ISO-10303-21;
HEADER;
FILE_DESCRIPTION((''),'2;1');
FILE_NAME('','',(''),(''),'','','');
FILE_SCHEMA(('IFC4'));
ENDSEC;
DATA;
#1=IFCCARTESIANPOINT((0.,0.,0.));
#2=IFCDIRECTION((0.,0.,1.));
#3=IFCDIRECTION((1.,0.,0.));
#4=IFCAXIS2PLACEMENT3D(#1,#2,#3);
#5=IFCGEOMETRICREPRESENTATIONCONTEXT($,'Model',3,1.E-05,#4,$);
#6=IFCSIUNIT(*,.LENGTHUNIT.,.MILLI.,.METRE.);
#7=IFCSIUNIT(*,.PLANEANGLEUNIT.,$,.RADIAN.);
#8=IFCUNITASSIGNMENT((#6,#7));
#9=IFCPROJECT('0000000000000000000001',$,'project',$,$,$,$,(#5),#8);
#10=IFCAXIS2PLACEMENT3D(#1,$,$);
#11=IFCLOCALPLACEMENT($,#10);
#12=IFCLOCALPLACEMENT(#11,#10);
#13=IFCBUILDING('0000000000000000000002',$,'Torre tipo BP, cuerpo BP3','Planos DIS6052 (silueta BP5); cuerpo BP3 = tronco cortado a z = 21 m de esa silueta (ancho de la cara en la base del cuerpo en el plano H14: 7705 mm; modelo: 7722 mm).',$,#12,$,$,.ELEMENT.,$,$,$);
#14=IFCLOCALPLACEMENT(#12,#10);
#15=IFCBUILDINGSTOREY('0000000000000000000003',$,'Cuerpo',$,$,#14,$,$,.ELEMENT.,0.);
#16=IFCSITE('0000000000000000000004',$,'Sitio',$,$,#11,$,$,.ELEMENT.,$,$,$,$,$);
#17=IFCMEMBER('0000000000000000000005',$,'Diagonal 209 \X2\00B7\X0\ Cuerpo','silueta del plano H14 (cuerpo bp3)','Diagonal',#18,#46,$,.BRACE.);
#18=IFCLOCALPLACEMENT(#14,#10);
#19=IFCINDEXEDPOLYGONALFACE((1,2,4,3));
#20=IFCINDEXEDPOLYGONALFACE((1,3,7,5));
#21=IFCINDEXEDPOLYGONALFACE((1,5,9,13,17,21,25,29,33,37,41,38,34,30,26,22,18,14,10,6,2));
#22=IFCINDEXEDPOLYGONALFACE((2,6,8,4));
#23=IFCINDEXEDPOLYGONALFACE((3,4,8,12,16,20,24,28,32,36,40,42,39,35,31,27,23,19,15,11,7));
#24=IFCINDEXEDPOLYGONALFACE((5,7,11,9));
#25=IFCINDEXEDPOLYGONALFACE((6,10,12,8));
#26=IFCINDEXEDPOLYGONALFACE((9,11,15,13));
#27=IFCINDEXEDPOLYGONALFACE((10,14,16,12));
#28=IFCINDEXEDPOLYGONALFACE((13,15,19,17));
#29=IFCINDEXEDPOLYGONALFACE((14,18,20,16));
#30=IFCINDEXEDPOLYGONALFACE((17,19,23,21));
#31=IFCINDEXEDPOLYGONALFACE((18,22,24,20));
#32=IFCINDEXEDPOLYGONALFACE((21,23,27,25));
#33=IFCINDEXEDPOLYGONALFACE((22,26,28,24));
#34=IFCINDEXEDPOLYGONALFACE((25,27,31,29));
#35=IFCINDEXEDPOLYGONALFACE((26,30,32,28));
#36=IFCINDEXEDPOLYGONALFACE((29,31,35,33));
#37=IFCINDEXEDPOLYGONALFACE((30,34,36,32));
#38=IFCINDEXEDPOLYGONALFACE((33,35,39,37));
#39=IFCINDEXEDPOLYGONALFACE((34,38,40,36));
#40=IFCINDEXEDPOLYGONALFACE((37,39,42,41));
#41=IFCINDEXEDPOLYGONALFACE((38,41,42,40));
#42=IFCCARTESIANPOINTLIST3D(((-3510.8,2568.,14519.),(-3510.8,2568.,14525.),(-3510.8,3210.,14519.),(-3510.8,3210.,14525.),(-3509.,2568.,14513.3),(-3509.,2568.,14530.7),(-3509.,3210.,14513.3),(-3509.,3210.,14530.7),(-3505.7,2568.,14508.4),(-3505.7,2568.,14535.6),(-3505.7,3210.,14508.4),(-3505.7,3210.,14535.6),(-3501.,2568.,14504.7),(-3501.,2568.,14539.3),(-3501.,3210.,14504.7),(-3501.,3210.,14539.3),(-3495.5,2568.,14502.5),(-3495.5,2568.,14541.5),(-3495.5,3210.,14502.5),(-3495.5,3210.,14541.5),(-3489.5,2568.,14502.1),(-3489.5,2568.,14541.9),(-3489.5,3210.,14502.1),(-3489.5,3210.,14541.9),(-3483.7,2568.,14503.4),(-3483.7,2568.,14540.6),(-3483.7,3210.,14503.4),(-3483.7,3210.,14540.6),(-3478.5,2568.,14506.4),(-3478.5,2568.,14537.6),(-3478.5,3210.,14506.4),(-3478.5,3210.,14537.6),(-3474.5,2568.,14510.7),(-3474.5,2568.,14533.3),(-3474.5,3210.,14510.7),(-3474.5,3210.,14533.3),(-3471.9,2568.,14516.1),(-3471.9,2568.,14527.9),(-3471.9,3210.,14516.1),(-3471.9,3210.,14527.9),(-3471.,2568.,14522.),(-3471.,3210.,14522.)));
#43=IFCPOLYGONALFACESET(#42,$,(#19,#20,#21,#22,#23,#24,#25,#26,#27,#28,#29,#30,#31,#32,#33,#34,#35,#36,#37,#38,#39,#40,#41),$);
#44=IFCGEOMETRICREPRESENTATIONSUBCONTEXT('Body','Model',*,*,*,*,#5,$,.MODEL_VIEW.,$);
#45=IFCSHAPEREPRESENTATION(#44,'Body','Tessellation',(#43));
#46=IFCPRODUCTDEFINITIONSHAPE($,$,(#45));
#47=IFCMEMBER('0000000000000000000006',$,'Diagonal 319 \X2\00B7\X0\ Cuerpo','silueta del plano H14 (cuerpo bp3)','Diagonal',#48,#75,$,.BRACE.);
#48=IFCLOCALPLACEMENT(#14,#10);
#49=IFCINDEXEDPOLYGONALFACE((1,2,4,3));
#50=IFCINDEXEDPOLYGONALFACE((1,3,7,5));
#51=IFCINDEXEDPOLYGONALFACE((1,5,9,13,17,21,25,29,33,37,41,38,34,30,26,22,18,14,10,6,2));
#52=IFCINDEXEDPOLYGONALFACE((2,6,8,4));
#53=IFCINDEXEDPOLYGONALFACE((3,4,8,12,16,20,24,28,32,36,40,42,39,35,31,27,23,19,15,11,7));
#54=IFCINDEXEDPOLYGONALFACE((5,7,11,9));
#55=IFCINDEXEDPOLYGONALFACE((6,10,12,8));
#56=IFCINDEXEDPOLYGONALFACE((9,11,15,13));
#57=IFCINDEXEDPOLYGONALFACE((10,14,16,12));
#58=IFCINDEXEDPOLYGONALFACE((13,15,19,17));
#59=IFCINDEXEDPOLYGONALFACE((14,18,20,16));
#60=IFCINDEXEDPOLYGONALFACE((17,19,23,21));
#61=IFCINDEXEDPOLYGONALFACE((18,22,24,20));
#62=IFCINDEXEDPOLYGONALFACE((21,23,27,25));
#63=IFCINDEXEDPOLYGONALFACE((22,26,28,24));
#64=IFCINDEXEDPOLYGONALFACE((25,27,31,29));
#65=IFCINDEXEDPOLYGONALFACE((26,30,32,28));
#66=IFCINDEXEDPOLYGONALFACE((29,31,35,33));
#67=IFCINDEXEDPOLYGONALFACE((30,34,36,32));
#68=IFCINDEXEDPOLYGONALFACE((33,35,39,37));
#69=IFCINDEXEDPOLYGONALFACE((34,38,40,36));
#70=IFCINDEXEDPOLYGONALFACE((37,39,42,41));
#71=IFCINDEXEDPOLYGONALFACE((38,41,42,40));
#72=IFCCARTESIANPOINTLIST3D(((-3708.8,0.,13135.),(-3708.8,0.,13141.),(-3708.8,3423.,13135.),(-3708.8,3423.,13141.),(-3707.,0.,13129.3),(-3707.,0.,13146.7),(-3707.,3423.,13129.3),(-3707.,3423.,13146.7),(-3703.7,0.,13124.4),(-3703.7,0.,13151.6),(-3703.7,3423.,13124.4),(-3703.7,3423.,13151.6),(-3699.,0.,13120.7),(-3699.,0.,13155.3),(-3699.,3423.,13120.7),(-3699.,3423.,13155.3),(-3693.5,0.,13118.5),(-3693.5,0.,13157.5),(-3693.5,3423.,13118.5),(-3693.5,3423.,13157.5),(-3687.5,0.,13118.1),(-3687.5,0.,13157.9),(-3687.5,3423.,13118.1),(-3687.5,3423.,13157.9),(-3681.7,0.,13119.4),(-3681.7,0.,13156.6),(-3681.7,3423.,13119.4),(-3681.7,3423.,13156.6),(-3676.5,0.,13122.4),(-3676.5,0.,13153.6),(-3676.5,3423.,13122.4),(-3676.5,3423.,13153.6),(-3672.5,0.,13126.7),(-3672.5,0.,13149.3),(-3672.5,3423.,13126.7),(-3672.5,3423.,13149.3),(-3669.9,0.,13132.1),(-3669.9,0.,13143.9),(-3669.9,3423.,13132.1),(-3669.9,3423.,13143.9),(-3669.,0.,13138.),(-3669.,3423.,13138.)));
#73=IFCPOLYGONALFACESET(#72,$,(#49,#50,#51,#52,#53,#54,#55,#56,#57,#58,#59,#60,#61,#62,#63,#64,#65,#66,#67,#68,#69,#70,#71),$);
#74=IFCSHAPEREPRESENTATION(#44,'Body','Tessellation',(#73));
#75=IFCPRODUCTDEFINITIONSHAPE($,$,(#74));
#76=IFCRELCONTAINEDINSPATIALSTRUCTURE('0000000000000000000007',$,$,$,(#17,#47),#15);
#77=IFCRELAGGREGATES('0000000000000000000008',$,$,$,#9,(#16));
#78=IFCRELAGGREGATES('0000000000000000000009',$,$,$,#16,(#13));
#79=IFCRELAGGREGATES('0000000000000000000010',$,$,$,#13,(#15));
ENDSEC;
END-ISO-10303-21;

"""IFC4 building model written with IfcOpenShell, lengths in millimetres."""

from ifc_helpers import new_model, si_unit, frame, origin, origin_with_axes, place, context, subcontext, project, spatial, circle, extrude, element, save


model = new_model("IFC4")

# Units and contexts
model_context = context("Model", 3, precision=1e-05, world=origin_with_axes())
body_context = subcontext(model_context, "Body", "Model", "MODEL_VIEW")
ifc_project = project(units=[si_unit("LENGTHUNIT", "METRE", prefix="MILLI"), si_unit("PLANEANGLEUNIT", "RADIAN")], contexts=[model_context])

# Site, building, storey
site_placement = place(None, origin())
site = spatial("IfcSite", under=ifc_project, at=site_placement, Name="Sitio", CompositionType="ELEMENT")
building_placement = place(site_placement, origin())
building = spatial("IfcBuilding", under=site, at=building_placement, Name="Torre tipo BP, cuerpo BP3", Description="Planos DIS6052 (silueta BP5); cuerpo BP3 = tronco cortado a z = 21 m de esa silueta (ancho de la cara en la base del cuerpo en el plano H14: 7705 mm; modelo: 7722 mm).", CompositionType="ELEMENT")
storey_placement = place(building_placement, origin())
storey = spatial("IfcBuildingStorey", under=building, at=storey_placement, Name="Cuerpo", CompositionType="ELEMENT", Elevation=0.0)

# Members
member_1_placement = place(storey_placement, frame((-3491.0, 2568.0, 14522.0), z_axis=(0.0, 1.0, 0.0), x_axis=(1.0, 0.0, 0.0)))
element("IfcMember", 1, at=member_1_placement, inside=storey, Name="Diagonal 209 · Cuerpo", Description="silueta del plano H14 (cuerpo bp3)", ObjectType="Diagonal", PredefinedType="BRACE", context=body_context, shape_type="SweptSolid", body=[
    extrude(circle(Radius=20.0), None, (0.0, 0.0, 1.0), 642.0),
])
member_2_placement = place(storey_placement, frame((-3689.0, 3423.0, 13138.0), z_axis=(0.0, -1.0, 0.0), x_axis=(1.0, 0.0, 0.0)))
element("IfcMember", 2, at=member_2_placement, inside=storey, Name="Diagonal 319 · Cuerpo", Description="silueta del plano H14 (cuerpo bp3)", ObjectType="Diagonal", PredefinedType="BRACE", context=body_context, shape_type="SweptSolid", body=[
    extrude(circle(Radius=20.0), None, (0.0, 0.0, 1.0), 3423.0),
])

save(model, "model.ifc")
